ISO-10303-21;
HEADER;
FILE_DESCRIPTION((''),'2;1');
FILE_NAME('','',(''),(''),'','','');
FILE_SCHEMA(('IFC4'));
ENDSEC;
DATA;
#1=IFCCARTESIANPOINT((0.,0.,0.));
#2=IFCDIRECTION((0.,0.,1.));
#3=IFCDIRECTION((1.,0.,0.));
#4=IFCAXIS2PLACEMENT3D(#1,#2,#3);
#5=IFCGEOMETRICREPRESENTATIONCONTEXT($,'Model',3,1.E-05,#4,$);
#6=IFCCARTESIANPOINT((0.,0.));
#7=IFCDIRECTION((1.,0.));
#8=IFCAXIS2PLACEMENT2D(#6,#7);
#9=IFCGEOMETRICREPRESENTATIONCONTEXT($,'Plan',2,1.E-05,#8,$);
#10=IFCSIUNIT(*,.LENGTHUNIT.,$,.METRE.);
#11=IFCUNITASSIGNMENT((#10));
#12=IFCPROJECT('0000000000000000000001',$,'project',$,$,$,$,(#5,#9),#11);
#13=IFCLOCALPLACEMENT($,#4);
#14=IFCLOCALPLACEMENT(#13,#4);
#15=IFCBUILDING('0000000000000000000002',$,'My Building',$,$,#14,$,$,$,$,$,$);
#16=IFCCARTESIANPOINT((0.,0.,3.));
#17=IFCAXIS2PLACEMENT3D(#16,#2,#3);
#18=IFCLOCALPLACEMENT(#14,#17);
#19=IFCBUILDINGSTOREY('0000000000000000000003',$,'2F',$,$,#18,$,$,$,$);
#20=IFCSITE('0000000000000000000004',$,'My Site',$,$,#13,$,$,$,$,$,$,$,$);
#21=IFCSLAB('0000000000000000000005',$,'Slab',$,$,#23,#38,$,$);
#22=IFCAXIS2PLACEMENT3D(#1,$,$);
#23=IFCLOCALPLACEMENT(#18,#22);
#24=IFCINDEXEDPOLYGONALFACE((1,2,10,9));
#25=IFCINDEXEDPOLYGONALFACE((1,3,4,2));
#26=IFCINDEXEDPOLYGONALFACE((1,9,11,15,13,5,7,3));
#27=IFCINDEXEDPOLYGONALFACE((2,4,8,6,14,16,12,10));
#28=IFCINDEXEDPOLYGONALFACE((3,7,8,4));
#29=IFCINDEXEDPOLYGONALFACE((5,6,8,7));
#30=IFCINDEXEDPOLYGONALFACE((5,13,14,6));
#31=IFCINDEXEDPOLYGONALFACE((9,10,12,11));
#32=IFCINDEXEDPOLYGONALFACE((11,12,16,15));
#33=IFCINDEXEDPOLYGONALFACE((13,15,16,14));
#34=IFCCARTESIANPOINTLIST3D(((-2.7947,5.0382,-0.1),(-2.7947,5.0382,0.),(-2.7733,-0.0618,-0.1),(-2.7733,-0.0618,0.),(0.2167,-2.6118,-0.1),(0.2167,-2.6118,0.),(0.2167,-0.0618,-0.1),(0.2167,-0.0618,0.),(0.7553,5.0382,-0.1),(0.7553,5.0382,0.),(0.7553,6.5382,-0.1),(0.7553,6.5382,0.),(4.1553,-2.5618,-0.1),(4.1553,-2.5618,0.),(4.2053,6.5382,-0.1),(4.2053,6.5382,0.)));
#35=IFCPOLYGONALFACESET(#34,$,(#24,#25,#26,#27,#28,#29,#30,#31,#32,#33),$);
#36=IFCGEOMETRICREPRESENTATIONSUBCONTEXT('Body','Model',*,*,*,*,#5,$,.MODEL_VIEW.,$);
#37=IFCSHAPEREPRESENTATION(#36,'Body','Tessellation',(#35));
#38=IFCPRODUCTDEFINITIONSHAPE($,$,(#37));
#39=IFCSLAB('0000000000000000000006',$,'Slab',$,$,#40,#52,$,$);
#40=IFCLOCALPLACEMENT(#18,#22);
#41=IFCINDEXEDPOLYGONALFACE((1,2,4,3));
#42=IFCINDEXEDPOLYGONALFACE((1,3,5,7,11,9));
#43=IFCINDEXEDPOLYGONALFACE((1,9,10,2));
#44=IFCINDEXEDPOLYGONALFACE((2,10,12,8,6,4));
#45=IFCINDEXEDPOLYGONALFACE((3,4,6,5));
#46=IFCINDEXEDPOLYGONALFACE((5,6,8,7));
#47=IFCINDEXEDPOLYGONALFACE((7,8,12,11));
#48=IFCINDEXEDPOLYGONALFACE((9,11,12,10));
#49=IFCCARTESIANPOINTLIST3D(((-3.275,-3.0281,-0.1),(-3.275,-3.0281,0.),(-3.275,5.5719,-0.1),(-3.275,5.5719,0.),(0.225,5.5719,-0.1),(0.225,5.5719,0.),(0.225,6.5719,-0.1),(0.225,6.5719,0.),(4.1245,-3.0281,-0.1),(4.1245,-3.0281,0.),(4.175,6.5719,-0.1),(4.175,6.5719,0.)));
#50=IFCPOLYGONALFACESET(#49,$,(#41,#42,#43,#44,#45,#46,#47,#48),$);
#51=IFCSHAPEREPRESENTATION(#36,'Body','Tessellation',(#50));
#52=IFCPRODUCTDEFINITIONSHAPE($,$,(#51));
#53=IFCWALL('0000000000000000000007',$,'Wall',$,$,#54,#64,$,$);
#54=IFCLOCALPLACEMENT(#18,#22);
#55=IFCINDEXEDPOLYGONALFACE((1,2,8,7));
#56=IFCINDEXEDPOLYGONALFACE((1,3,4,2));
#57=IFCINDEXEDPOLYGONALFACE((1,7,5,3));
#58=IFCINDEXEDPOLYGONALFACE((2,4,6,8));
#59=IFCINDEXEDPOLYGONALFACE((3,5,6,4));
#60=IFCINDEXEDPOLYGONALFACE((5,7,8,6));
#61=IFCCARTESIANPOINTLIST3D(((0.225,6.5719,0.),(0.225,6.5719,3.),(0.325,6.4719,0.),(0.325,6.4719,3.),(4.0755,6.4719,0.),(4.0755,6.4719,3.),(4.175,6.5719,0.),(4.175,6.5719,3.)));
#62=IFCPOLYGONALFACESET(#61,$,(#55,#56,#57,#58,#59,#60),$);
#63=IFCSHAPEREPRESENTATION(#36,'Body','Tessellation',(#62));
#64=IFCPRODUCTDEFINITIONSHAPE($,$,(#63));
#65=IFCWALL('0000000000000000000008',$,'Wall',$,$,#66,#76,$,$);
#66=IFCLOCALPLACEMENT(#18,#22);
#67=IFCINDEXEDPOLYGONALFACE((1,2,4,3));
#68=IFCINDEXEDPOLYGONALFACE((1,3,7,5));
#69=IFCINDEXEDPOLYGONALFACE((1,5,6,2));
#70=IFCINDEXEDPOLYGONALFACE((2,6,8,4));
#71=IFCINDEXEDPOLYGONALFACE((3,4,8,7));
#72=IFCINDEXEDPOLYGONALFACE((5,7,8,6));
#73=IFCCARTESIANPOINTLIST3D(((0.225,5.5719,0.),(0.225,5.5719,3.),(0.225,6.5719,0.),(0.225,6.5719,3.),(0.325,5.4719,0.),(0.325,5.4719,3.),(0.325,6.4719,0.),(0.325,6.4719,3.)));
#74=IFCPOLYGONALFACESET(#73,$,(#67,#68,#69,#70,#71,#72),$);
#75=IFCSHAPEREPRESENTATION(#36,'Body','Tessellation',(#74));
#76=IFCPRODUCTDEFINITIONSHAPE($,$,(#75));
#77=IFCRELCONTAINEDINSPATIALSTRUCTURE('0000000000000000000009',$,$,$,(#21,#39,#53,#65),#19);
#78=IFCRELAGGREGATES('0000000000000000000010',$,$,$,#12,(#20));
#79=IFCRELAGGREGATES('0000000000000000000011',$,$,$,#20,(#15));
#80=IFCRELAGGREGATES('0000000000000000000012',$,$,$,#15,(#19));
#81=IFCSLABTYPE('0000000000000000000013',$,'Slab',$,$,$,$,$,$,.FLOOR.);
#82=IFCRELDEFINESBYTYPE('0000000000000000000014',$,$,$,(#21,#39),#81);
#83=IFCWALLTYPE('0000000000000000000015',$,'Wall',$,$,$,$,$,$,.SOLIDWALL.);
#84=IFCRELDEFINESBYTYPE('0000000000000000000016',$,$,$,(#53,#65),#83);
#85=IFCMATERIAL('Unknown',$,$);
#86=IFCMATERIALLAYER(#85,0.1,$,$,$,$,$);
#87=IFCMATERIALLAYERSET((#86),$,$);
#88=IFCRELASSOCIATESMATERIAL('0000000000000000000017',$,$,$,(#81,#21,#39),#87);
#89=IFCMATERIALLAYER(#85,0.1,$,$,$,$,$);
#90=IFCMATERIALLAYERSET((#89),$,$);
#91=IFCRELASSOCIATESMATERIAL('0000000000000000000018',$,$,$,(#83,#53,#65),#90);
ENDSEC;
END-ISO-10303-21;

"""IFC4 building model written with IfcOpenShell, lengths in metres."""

from ifc_helpers import new_model, si_unit, frame, origin_with_axes, origin_2d_with_axis, place, context, subcontext, project, spatial, line, indexed_curve, outline, extrude, material, layer, layer_set, layer_usage, type_object, element, save


model = new_model("IFC4")

# Units and contexts
model_context = context("Model", 3, precision=1e-05, world=origin_with_axes())
plan_context = context("Plan", 2, precision=1e-05, world=origin_2d_with_axis())
body_context_1 = subcontext(model_context, "Body", "Model", "MODEL_VIEW")
ifc_project = project(units=[si_unit("LENGTHUNIT", "METRE")], contexts=[model_context, plan_context])

# Site, building, storey
site_placement = place(None, origin_with_axes())
site = spatial("IfcSite", under=ifc_project, at=site_placement, Name="My Site")
building_placement = place(site_placement, origin_with_axes())
building = spatial("IfcBuilding", under=site, at=building_placement, Name="My Building")
storey_placement = place(building_placement, frame((0.0, 0.0, 3.0), z_axis=(0.0, 0.0, 1.0), x_axis=(1.0, 0.0, 0.0)))
storey = spatial("IfcBuildingStorey", under=building, at=storey_placement, Name="2F")

# Slabs
ifc_material = material(Name="Unknown")
ifc_layer_1 = layer(ifc_material, 0.1)
ifc_layer_set_1 = layer_set([ifc_layer_1])
ifc_layer_usage_1 = layer_usage(ifc_layer_set_1, "AXIS3", "POSITIVE", -0.1)
slab_type = type_object("IfcSlabType", Name="Slab", PredefinedType="FLOOR", material=ifc_layer_set_1)
slab_1_placement = place(storey_placement, frame((0.7553, 6.5382, 0.0), z_axis=(0.0, 0.0, 1.0), x_axis=(1.0, 0.0, 0.0)))
element("IfcSlab", 1, at=slab_1_placement, inside=storey, type_object=slab_type, material=ifc_layer_usage_1, Name="Slab", context=body_context_1, shape_type="SweptSolid", body=[
    extrude(outline(indexed_curve([(0.0, 0.0), (0.0, -1.5), (-3.55, -1.5), (-3.5286, -6.6), (-0.5386, -6.6), (-0.5386, -9.15), (3.4, -9.1), (3.45, 0.0), (0.0, 0.0)])), frame((0.0, 0.0, -0.1), z_axis=(0.0, 0.0, 1.0), x_axis=(1.0, 0.0, 0.0)), (0.0, 0.0, 1.0), 0.1),
])
ifc_layer_usage_2 = layer_usage(ifc_layer_set_1, "AXIS3", "POSITIVE", -0.1)
slab_2_placement = place(storey_placement, frame((4.175, 6.5719, 0.0), z_axis=(0.0, 0.0, 1.0), x_axis=(1.0, 0.0, 0.0)))
element("IfcSlab", 2, at=slab_2_placement, inside=storey, type_object=slab_type, material=ifc_layer_usage_2, Name="Slab", context=body_context_1, shape_type="SweptSolid", body=[
    extrude(outline(indexed_curve([(0.0, 0.0), (-3.95, 0.0), (-3.95, -1.0), (-7.45, -1.0), (-7.45, -9.6), (-0.0505, -9.6), (0.0, 0.0)])), frame((0.0, 0.0, -0.1), z_axis=(0.0, 0.0, 1.0), x_axis=(1.0, 0.0, 0.0)), (0.0, 0.0, 1.0), 0.1),
])

# Walls
ifc_layer_2 = layer(ifc_material, 0.1)
ifc_layer_set_2 = layer_set([ifc_layer_2])
ifc_layer_usage_3 = layer_usage(ifc_layer_set_2, "AXIS2", "POSITIVE", 0.0)
wall_type = type_object("IfcWallType", Name="Wall", PredefinedType="SOLIDWALL", material=ifc_layer_set_2)
wall_1_placement = place(storey_placement, frame((4.175, 6.5719, 0.0), z_axis=(0.0, 0.0, 1.0), x_axis=(-1.0, 0.0, 0.0)))
element("IfcWall", 3, at=wall_1_placement, inside=storey, type_object=wall_type, material=ifc_layer_usage_3, Name="Wall", context=body_context_1, shape_type="SweptSolid", body=[
    extrude(outline(indexed_curve([(0.0, 0.0), (0.0995, 0.1), (3.85, 0.1), (3.95, 0.0)], segments=[line(1, 2, 3, 4, 1)])), origin_with_axes(), (0.0, 0.0, 1.0), 3.0),
])
ifc_layer_usage_4 = layer_usage(ifc_layer_set_2, "AXIS2", "POSITIVE", 0.0)
wall_2_placement = place(storey_placement, frame((0.225, 6.5719, 0.0), z_axis=(0.0, 0.0, 1.0), x_axis=(0.0, -1.0, 0.0)))
element("IfcWall", 4, at=wall_2_placement, inside=storey, type_object=wall_type, material=ifc_layer_usage_4, Name="Wall", context=body_context_1, shape_type="SweptSolid", body=[
    extrude(outline(indexed_curve([(0.0, 0.0), (0.1, 0.1), (1.1, 0.1), (1.0, 0.0)], segments=[line(1, 2, 3, 4, 1)])), origin_with_axes(), (0.0, 0.0, 1.0), 3.0),
])

save(model, "model.ifc")
